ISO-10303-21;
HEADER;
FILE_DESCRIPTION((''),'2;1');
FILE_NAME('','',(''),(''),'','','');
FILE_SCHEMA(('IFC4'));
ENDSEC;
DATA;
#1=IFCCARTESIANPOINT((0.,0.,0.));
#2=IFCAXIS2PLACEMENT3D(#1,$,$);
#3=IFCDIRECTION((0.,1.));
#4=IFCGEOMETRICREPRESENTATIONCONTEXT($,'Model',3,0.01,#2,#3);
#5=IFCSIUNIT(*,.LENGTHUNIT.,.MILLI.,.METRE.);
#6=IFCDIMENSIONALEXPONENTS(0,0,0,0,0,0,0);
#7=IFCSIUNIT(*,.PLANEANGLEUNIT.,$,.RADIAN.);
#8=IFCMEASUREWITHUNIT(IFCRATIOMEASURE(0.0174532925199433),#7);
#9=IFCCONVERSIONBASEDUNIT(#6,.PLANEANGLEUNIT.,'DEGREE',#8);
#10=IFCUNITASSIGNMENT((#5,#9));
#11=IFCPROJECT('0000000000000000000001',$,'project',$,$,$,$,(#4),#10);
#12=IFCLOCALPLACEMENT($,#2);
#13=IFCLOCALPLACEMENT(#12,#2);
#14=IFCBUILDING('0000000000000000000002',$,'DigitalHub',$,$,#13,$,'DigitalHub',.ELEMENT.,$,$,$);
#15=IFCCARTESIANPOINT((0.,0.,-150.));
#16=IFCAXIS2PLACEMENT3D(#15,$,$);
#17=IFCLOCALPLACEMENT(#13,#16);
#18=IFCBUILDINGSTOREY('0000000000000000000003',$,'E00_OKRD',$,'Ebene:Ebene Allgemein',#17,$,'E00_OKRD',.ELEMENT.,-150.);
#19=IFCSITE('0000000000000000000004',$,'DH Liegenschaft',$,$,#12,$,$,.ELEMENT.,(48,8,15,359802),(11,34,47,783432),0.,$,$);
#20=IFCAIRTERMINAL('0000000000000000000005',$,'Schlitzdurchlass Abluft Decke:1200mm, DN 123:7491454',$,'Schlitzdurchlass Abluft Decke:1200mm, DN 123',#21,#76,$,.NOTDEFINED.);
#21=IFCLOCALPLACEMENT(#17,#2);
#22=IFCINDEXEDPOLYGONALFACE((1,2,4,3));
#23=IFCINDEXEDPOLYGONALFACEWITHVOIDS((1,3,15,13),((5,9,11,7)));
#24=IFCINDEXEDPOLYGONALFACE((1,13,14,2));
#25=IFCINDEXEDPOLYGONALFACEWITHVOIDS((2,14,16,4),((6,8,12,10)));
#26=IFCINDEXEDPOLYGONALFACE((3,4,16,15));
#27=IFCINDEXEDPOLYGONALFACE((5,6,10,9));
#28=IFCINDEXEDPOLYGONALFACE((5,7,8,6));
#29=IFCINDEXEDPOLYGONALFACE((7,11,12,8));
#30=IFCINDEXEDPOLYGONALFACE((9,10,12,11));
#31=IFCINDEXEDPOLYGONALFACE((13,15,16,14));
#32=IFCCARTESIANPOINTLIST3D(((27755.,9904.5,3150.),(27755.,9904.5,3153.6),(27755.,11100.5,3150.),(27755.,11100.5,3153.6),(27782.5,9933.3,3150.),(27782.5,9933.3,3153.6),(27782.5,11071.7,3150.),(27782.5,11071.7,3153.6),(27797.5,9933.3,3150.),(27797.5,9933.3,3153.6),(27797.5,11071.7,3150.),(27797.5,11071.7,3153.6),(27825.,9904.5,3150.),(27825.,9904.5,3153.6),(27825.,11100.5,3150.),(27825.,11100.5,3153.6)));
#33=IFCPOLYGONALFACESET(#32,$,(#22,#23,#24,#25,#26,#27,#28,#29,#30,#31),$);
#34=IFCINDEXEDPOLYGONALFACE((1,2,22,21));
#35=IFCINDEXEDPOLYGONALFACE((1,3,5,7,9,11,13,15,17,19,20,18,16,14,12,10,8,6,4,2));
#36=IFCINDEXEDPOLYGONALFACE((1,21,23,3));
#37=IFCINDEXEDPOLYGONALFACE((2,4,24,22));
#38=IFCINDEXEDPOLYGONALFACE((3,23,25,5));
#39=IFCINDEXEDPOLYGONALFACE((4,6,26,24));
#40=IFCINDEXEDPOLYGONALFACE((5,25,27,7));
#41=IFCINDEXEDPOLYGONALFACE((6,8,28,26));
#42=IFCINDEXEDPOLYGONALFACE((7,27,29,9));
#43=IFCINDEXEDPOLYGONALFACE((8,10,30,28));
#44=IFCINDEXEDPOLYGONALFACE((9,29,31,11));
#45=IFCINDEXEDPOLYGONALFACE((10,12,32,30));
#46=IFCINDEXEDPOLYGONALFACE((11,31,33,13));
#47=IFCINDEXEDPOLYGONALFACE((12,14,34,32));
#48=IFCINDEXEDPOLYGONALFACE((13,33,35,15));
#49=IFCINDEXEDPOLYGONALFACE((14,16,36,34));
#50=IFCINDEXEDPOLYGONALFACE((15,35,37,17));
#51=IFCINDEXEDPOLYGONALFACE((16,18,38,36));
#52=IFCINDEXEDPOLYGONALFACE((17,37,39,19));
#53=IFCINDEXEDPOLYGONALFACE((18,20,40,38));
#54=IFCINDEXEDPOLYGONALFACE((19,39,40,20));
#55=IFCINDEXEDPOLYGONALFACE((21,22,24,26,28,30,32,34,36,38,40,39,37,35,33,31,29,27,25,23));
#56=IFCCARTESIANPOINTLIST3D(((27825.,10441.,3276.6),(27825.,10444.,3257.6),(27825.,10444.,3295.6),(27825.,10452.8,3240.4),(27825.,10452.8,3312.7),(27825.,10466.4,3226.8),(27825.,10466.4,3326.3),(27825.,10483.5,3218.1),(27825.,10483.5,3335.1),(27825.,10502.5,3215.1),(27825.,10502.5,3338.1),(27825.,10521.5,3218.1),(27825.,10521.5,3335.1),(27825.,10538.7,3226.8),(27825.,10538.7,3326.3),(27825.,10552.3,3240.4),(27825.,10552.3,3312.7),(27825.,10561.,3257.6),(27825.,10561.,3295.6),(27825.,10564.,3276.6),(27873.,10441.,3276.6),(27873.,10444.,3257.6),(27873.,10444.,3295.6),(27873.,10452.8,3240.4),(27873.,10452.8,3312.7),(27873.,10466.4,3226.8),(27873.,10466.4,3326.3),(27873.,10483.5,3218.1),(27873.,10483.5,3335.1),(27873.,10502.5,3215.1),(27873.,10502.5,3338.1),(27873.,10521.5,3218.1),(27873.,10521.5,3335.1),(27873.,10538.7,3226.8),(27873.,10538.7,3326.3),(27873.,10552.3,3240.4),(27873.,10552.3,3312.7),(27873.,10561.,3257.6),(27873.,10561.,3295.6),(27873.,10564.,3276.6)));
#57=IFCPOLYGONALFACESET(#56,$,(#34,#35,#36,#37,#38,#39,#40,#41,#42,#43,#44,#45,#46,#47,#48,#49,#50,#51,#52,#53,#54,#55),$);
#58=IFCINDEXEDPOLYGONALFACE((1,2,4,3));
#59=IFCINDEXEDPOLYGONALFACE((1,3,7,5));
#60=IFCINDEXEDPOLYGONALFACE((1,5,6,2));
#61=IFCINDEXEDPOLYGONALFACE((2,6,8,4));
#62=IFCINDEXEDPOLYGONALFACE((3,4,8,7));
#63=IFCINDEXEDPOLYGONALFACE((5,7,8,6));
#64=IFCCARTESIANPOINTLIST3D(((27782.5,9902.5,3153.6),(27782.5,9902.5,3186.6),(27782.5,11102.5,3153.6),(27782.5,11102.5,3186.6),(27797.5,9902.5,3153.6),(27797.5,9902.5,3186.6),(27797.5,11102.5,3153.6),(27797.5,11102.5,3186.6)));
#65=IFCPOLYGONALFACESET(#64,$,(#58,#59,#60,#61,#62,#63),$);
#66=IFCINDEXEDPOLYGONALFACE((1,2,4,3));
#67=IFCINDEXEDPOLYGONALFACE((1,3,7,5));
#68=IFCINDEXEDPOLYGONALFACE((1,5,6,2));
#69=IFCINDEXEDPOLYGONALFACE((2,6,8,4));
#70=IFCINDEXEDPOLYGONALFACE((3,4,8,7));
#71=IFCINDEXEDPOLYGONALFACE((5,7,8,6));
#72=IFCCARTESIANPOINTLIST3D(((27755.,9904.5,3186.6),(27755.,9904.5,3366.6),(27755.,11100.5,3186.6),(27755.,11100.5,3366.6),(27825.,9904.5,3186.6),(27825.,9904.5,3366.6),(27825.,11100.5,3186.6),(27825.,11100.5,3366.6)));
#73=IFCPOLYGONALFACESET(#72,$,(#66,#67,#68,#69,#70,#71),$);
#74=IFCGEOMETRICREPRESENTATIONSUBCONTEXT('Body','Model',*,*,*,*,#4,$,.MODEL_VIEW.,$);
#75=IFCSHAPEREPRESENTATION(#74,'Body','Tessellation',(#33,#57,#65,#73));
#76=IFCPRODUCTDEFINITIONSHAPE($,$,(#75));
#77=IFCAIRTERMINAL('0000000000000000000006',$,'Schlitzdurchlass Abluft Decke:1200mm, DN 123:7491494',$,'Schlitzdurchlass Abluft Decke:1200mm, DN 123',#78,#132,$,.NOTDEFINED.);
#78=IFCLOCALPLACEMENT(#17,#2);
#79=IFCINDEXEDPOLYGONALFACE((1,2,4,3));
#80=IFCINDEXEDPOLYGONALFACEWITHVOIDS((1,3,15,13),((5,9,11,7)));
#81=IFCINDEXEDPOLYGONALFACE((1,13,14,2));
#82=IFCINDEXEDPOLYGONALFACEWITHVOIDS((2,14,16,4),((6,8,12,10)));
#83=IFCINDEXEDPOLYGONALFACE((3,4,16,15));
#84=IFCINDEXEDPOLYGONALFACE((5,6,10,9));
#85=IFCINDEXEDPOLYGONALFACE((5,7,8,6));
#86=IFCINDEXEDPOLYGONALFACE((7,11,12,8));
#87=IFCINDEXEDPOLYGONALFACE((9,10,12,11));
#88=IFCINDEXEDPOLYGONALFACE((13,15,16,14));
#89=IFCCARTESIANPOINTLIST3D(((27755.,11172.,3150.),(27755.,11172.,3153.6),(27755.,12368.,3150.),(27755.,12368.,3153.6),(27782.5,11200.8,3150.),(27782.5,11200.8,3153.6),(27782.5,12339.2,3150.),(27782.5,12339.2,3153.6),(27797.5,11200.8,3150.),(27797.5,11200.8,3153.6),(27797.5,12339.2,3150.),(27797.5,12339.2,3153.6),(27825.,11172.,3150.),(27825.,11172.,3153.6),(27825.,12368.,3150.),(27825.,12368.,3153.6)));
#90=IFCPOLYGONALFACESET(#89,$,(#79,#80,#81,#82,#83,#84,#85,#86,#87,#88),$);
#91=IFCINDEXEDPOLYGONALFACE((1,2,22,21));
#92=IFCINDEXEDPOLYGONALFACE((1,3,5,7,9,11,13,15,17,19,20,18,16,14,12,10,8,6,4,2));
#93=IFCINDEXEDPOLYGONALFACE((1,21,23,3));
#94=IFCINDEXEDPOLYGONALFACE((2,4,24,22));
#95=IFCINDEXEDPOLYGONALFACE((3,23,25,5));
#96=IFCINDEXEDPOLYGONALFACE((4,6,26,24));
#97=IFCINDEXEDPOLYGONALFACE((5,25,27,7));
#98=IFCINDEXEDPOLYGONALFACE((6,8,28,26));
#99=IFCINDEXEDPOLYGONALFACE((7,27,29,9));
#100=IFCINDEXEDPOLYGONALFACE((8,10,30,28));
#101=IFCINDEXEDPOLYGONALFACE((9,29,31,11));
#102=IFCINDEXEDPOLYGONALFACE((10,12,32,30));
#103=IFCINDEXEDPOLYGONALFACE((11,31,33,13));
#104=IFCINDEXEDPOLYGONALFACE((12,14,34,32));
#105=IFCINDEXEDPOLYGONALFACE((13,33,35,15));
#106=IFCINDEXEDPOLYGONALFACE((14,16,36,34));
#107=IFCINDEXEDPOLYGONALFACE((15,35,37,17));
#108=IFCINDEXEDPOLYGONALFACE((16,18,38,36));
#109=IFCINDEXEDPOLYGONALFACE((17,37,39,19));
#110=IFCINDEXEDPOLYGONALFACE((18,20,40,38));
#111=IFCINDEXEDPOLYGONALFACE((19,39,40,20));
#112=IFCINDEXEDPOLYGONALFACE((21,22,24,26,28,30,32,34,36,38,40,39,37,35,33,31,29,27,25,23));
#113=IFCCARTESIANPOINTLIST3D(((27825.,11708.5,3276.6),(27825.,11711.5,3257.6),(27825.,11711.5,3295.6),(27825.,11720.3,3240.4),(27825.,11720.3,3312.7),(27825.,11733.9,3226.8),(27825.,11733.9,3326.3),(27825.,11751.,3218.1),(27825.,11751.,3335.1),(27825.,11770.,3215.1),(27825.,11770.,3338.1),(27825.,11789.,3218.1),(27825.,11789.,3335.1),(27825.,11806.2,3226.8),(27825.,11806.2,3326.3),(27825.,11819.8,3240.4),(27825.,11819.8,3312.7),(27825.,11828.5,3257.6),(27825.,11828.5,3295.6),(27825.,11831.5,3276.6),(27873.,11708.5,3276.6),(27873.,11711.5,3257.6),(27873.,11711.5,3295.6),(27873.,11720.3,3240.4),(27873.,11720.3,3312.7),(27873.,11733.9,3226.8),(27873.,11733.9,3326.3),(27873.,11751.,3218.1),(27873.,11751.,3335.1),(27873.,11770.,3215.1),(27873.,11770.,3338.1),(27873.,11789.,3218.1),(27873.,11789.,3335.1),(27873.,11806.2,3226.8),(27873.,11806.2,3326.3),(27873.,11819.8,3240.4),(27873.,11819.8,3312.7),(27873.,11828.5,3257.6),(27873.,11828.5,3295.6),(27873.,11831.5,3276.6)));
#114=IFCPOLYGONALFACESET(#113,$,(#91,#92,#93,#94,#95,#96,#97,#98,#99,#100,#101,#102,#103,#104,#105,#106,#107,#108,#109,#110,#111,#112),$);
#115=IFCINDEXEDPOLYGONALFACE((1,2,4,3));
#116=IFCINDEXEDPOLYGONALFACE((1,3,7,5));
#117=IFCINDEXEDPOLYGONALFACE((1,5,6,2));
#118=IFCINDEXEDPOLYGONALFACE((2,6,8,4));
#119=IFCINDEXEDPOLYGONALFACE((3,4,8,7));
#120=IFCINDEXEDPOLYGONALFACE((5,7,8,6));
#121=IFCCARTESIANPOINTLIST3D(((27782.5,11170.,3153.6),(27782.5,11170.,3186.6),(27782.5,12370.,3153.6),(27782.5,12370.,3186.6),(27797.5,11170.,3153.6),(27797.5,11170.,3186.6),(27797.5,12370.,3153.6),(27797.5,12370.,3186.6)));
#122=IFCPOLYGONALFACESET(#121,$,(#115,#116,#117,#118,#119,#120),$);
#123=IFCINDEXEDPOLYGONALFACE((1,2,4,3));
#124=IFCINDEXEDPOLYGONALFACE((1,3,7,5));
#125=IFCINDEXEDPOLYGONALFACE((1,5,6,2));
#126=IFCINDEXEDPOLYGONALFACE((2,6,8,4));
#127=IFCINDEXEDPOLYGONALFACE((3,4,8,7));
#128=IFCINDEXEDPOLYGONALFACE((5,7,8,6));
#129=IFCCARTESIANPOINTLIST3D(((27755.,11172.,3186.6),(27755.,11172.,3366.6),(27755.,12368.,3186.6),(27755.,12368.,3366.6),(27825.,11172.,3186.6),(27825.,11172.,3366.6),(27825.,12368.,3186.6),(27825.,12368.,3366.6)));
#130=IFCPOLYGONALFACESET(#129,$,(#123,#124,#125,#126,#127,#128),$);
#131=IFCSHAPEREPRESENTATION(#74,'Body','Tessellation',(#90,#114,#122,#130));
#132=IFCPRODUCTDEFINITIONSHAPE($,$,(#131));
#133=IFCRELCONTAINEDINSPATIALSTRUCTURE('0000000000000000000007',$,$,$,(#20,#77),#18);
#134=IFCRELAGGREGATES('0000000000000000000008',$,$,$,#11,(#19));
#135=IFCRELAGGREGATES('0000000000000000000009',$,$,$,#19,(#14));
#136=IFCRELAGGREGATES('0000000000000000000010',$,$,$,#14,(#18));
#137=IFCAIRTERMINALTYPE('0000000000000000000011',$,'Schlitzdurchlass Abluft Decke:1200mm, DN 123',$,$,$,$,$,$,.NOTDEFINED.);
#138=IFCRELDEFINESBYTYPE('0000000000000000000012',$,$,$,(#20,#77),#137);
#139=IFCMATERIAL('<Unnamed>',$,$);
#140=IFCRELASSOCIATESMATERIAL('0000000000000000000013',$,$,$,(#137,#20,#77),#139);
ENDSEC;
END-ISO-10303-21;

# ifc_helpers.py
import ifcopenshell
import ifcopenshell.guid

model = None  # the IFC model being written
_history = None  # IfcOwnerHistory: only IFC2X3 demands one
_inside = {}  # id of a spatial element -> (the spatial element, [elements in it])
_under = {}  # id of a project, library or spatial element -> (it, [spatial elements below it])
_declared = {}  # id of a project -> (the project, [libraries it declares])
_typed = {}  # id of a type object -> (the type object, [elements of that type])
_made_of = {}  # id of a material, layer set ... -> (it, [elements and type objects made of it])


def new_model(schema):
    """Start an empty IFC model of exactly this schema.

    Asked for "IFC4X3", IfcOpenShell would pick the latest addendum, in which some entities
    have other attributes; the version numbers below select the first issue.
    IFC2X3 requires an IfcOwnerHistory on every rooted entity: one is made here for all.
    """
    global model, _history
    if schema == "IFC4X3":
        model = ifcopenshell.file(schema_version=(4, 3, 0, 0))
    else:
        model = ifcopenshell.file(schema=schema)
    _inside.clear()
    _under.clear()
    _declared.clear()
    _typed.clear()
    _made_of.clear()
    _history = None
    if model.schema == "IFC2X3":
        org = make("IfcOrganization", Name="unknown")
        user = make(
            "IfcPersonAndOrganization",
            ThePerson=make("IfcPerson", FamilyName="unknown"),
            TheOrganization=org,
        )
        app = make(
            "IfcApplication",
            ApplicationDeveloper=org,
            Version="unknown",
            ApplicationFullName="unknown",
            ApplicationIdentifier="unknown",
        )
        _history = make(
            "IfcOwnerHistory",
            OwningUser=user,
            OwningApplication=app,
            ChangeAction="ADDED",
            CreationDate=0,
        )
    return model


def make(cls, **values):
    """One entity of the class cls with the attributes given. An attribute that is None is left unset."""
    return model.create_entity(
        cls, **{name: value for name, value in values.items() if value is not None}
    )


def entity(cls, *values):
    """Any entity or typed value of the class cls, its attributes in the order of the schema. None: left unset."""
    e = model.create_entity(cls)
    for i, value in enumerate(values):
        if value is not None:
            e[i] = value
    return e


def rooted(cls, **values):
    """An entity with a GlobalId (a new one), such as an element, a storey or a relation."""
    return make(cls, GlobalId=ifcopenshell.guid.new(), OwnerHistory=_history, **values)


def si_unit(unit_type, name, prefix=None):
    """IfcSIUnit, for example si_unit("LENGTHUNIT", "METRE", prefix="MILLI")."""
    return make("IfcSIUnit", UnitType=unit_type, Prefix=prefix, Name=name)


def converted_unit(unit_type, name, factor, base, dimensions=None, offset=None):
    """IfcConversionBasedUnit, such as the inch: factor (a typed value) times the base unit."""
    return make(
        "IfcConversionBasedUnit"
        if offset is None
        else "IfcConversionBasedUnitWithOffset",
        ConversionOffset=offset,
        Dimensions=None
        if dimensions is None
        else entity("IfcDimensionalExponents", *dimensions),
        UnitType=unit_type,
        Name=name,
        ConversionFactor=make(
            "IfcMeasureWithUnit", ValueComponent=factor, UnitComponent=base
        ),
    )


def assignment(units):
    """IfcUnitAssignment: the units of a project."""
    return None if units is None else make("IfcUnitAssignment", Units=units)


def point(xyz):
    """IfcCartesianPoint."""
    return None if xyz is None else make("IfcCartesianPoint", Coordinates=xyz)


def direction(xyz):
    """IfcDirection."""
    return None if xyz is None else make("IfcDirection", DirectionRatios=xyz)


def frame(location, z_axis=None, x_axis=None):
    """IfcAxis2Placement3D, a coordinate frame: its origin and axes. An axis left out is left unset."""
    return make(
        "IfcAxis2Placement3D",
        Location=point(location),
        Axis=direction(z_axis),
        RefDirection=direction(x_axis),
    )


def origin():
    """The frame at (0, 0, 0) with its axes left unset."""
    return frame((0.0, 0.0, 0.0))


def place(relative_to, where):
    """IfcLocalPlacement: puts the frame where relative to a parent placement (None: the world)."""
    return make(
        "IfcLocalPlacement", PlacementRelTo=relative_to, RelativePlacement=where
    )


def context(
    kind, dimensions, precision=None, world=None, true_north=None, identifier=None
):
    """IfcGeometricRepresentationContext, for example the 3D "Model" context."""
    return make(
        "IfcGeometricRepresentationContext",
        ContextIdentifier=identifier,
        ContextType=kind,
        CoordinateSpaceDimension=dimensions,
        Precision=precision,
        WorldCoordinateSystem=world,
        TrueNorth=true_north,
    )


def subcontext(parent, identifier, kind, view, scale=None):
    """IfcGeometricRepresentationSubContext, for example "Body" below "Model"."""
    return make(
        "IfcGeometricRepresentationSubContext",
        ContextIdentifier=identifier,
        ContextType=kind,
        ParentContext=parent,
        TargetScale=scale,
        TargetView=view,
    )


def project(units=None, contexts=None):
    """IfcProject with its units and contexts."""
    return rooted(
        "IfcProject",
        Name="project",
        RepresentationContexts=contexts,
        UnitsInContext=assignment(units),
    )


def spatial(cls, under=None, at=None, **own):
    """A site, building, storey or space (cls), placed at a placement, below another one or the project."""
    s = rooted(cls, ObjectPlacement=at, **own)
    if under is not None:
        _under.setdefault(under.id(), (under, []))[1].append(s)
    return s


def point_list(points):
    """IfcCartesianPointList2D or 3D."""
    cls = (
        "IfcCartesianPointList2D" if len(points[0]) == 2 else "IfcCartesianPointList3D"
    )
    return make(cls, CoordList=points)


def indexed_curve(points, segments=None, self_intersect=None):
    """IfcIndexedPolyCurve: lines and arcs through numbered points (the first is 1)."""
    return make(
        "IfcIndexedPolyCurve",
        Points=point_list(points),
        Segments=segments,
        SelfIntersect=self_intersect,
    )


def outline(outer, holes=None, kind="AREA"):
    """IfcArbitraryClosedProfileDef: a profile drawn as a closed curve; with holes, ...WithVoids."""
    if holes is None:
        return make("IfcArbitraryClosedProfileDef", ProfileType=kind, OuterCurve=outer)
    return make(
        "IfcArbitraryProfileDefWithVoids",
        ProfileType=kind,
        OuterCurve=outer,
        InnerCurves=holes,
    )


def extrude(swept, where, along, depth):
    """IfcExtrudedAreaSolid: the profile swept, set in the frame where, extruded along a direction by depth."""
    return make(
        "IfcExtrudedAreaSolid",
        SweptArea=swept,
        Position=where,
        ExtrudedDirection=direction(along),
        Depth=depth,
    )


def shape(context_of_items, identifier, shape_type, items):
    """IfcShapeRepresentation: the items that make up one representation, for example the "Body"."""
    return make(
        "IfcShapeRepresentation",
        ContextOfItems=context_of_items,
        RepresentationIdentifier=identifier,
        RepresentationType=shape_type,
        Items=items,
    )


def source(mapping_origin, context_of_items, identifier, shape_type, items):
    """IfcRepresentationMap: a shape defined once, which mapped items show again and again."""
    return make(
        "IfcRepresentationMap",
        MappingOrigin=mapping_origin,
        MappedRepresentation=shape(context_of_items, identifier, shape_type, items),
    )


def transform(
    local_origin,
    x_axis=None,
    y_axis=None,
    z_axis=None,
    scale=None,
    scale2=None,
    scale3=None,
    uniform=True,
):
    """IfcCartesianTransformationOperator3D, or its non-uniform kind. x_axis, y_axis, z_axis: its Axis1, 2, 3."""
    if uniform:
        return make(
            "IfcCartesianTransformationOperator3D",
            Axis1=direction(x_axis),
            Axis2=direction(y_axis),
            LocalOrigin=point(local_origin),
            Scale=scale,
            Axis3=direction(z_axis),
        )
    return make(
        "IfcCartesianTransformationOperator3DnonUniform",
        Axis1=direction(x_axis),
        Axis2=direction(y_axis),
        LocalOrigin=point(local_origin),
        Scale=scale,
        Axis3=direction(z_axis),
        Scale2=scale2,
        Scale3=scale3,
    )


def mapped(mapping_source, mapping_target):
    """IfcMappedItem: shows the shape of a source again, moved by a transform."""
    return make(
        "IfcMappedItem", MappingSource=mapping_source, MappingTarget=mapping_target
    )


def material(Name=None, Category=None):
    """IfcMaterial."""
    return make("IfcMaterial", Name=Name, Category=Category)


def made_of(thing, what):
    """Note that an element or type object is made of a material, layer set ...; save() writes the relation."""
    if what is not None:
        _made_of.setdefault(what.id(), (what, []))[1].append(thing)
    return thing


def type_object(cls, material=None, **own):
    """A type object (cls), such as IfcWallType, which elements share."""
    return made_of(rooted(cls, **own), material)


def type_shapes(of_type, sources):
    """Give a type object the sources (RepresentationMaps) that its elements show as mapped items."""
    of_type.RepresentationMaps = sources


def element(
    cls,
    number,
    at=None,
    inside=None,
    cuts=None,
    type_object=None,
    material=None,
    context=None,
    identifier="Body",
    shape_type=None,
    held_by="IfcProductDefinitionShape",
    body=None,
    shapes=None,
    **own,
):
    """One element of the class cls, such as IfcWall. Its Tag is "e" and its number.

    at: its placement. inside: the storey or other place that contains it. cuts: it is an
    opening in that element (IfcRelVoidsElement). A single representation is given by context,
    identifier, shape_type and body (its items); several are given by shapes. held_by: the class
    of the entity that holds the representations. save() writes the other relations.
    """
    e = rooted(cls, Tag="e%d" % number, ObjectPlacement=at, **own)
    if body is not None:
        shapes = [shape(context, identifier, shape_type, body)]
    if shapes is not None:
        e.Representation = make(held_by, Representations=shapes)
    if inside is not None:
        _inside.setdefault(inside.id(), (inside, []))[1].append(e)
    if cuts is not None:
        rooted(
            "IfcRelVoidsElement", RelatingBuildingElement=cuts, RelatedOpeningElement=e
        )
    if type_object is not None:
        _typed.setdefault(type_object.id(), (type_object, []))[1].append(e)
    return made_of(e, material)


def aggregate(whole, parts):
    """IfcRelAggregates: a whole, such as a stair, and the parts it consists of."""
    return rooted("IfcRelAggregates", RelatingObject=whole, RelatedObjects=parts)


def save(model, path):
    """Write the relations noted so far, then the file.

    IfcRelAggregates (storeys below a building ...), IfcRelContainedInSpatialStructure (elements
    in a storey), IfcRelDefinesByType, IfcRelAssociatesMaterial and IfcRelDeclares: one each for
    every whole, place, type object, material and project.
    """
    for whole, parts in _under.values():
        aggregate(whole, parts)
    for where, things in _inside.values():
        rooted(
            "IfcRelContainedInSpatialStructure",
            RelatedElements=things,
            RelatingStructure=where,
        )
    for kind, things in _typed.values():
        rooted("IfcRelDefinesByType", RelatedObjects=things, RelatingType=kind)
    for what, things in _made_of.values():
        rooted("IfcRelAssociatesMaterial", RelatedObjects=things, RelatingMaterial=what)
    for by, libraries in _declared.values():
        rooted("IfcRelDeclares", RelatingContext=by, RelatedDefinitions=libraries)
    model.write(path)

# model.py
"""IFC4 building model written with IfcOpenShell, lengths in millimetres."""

from ifc_helpers import new_model, entity, si_unit, converted_unit, direction, frame, origin, place, context, subcontext, project, spatial, indexed_curve, outline, extrude, source, transform, mapped, material, type_object, type_shapes, element, save


model = new_model("IFC4")

# Units and contexts
model_context = context("Model", 3, precision=0.01, world=origin(), true_north=direction((0.0, 1.0)))
body_context = subcontext(model_context, "Body", "Model", "MODEL_VIEW")
ifc_project = project(units=[si_unit("LENGTHUNIT", "METRE", prefix="MILLI"), converted_unit("PLANEANGLEUNIT", "DEGREE", entity("IfcRatioMeasure", 0.0174532925199433), si_unit("PLANEANGLEUNIT", "RADIAN"), dimensions=[0, 0, 0, 0, 0, 0, 0])], contexts=[model_context])

# Site, building, storey
site_placement = place(None, origin())
site = spatial("IfcSite", under=ifc_project, at=site_placement, Name="DH Liegenschaft", CompositionType="ELEMENT", RefLatitude=(48, 8, 15, 359802), RefLongitude=(11, 34, 47, 783432), RefElevation=0.0)
building_placement = place(site_placement, origin())
building = spatial("IfcBuilding", under=site, at=building_placement, Name="DigitalHub", LongName="DigitalHub", CompositionType="ELEMENT")
storey_placement = place(building_placement, frame((0.0, 0.0, -150.0)))
storey = spatial("IfcBuildingStorey", under=building, at=storey_placement, Name="E00_OKRD", ObjectType="Ebene:Ebene Allgemein", LongName="E00_OKRD", CompositionType="ELEMENT", Elevation=-150.0)

# Shared definitions
ifc_material_1 = material(Name="<Unnamed>")

# Air terminals
air_terminal_type_1 = type_object("IfcAirTerminalType", Name="Schlitzdurchlass Abluft Decke:1200mm, DN 123", PredefinedType="NOTDEFINED", material=ifc_material_1)
shared_shape_1 = source(origin(), body_context, "Body", "SweptSolid", [
    extrude(outline(indexed_curve([(-598.0, -35.0), (598.0, -35.0), (598.0, 35.0), (-598.0, 35.0), (-598.0, -35.0)], self_intersect=False), holes=[indexed_curve([(-569.2, -7.5), (-569.2, 7.5), (569.2, 7.5), (569.2, -7.5), (-569.2, -7.5)], self_intersect=False)]), frame((0.0, 0.0, 0.0), z_axis=(0.0, 0.0, 1.0), x_axis=(-1.0, 0.0, 0.0)), (0.0, 0.0, 1.0), 3.6),
    extrude(outline(indexed_curve([(61.5, 0.0), (58.5, 19.0), (49.8, 36.1), (36.1, 49.8), (19.0, 58.5), (0.0, 61.5), (-19.0, 58.5), (-36.1, 49.8), (-49.8, 36.1), (-58.5, 19.0), (-61.5, 0.0), (-58.5, -19.0), (-49.8, -36.1), (-36.1, -49.8), (-19.0, -58.5), (0.0, -61.5), (19.0, -58.5), (36.1, -49.8), (49.8, -36.1), (58.5, -19.0), (61.5, 0.0)], self_intersect=False)), frame((0.0, 35.0, 126.6), z_axis=(0.0, 1.0, 0.0), x_axis=(-1.0, 0.0, 0.0)), (0.0, 0.0, 1.0), 48.0),
    extrude(outline(indexed_curve([(-600.0, -7.5), (600.0, -7.5), (600.0, 7.5), (-600.0, 7.5), (-600.0, -7.5)], self_intersect=False)), frame((0.0, 0.0, 3.6), z_axis=(0.0, 0.0, 1.0), x_axis=(-1.0, 0.0, 0.0)), (0.0, 0.0, 1.0), 33.0),
    extrude(outline(indexed_curve([(-598.0, -35.0), (598.0, -35.0), (598.0, 35.0), (-598.0, 35.0), (-598.0, -35.0)], self_intersect=False)), frame((0.0, 0.0, 36.6), z_axis=(0.0, 0.0, 1.0), x_axis=(-1.0, 0.0, 0.0)), (0.0, 0.0, 1.0), 180.0),
])
type_shapes(air_terminal_type_1, [shared_shape_1])
for number, where, z_axis, x_axis, name in (
    (1, (27790.0, 10502.5, 3150.0), (0.0, 0.0, 1.0), (0.0, -1.0, 0.0), "Schlitzdurchlass Abluft Decke:1200mm, DN 123:7491454"),
    (2, (27790.0, 11770.0, 3150.0), (0.0, 0.0, 1.0), (0.0, -1.0, 0.0), "Schlitzdurchlass Abluft Decke:1200mm, DN 123:7491494"),
):
    element("IfcAirTerminal", number, at=place(storey_placement, frame(where, z_axis=z_axis, x_axis=x_axis)), inside=storey, type_object=air_terminal_type_1, material=ifc_material_1, Name=name, ObjectType="Schlitzdurchlass Abluft Decke:1200mm, DN 123", PredefinedType="NOTDEFINED", context=body_context, shape_type="MappedRepresentation", body=[
        mapped(shared_shape_1, transform((0.0, 0.0, 0.0), scale=1.0)),
    ])

save(model, "model.ifc")
